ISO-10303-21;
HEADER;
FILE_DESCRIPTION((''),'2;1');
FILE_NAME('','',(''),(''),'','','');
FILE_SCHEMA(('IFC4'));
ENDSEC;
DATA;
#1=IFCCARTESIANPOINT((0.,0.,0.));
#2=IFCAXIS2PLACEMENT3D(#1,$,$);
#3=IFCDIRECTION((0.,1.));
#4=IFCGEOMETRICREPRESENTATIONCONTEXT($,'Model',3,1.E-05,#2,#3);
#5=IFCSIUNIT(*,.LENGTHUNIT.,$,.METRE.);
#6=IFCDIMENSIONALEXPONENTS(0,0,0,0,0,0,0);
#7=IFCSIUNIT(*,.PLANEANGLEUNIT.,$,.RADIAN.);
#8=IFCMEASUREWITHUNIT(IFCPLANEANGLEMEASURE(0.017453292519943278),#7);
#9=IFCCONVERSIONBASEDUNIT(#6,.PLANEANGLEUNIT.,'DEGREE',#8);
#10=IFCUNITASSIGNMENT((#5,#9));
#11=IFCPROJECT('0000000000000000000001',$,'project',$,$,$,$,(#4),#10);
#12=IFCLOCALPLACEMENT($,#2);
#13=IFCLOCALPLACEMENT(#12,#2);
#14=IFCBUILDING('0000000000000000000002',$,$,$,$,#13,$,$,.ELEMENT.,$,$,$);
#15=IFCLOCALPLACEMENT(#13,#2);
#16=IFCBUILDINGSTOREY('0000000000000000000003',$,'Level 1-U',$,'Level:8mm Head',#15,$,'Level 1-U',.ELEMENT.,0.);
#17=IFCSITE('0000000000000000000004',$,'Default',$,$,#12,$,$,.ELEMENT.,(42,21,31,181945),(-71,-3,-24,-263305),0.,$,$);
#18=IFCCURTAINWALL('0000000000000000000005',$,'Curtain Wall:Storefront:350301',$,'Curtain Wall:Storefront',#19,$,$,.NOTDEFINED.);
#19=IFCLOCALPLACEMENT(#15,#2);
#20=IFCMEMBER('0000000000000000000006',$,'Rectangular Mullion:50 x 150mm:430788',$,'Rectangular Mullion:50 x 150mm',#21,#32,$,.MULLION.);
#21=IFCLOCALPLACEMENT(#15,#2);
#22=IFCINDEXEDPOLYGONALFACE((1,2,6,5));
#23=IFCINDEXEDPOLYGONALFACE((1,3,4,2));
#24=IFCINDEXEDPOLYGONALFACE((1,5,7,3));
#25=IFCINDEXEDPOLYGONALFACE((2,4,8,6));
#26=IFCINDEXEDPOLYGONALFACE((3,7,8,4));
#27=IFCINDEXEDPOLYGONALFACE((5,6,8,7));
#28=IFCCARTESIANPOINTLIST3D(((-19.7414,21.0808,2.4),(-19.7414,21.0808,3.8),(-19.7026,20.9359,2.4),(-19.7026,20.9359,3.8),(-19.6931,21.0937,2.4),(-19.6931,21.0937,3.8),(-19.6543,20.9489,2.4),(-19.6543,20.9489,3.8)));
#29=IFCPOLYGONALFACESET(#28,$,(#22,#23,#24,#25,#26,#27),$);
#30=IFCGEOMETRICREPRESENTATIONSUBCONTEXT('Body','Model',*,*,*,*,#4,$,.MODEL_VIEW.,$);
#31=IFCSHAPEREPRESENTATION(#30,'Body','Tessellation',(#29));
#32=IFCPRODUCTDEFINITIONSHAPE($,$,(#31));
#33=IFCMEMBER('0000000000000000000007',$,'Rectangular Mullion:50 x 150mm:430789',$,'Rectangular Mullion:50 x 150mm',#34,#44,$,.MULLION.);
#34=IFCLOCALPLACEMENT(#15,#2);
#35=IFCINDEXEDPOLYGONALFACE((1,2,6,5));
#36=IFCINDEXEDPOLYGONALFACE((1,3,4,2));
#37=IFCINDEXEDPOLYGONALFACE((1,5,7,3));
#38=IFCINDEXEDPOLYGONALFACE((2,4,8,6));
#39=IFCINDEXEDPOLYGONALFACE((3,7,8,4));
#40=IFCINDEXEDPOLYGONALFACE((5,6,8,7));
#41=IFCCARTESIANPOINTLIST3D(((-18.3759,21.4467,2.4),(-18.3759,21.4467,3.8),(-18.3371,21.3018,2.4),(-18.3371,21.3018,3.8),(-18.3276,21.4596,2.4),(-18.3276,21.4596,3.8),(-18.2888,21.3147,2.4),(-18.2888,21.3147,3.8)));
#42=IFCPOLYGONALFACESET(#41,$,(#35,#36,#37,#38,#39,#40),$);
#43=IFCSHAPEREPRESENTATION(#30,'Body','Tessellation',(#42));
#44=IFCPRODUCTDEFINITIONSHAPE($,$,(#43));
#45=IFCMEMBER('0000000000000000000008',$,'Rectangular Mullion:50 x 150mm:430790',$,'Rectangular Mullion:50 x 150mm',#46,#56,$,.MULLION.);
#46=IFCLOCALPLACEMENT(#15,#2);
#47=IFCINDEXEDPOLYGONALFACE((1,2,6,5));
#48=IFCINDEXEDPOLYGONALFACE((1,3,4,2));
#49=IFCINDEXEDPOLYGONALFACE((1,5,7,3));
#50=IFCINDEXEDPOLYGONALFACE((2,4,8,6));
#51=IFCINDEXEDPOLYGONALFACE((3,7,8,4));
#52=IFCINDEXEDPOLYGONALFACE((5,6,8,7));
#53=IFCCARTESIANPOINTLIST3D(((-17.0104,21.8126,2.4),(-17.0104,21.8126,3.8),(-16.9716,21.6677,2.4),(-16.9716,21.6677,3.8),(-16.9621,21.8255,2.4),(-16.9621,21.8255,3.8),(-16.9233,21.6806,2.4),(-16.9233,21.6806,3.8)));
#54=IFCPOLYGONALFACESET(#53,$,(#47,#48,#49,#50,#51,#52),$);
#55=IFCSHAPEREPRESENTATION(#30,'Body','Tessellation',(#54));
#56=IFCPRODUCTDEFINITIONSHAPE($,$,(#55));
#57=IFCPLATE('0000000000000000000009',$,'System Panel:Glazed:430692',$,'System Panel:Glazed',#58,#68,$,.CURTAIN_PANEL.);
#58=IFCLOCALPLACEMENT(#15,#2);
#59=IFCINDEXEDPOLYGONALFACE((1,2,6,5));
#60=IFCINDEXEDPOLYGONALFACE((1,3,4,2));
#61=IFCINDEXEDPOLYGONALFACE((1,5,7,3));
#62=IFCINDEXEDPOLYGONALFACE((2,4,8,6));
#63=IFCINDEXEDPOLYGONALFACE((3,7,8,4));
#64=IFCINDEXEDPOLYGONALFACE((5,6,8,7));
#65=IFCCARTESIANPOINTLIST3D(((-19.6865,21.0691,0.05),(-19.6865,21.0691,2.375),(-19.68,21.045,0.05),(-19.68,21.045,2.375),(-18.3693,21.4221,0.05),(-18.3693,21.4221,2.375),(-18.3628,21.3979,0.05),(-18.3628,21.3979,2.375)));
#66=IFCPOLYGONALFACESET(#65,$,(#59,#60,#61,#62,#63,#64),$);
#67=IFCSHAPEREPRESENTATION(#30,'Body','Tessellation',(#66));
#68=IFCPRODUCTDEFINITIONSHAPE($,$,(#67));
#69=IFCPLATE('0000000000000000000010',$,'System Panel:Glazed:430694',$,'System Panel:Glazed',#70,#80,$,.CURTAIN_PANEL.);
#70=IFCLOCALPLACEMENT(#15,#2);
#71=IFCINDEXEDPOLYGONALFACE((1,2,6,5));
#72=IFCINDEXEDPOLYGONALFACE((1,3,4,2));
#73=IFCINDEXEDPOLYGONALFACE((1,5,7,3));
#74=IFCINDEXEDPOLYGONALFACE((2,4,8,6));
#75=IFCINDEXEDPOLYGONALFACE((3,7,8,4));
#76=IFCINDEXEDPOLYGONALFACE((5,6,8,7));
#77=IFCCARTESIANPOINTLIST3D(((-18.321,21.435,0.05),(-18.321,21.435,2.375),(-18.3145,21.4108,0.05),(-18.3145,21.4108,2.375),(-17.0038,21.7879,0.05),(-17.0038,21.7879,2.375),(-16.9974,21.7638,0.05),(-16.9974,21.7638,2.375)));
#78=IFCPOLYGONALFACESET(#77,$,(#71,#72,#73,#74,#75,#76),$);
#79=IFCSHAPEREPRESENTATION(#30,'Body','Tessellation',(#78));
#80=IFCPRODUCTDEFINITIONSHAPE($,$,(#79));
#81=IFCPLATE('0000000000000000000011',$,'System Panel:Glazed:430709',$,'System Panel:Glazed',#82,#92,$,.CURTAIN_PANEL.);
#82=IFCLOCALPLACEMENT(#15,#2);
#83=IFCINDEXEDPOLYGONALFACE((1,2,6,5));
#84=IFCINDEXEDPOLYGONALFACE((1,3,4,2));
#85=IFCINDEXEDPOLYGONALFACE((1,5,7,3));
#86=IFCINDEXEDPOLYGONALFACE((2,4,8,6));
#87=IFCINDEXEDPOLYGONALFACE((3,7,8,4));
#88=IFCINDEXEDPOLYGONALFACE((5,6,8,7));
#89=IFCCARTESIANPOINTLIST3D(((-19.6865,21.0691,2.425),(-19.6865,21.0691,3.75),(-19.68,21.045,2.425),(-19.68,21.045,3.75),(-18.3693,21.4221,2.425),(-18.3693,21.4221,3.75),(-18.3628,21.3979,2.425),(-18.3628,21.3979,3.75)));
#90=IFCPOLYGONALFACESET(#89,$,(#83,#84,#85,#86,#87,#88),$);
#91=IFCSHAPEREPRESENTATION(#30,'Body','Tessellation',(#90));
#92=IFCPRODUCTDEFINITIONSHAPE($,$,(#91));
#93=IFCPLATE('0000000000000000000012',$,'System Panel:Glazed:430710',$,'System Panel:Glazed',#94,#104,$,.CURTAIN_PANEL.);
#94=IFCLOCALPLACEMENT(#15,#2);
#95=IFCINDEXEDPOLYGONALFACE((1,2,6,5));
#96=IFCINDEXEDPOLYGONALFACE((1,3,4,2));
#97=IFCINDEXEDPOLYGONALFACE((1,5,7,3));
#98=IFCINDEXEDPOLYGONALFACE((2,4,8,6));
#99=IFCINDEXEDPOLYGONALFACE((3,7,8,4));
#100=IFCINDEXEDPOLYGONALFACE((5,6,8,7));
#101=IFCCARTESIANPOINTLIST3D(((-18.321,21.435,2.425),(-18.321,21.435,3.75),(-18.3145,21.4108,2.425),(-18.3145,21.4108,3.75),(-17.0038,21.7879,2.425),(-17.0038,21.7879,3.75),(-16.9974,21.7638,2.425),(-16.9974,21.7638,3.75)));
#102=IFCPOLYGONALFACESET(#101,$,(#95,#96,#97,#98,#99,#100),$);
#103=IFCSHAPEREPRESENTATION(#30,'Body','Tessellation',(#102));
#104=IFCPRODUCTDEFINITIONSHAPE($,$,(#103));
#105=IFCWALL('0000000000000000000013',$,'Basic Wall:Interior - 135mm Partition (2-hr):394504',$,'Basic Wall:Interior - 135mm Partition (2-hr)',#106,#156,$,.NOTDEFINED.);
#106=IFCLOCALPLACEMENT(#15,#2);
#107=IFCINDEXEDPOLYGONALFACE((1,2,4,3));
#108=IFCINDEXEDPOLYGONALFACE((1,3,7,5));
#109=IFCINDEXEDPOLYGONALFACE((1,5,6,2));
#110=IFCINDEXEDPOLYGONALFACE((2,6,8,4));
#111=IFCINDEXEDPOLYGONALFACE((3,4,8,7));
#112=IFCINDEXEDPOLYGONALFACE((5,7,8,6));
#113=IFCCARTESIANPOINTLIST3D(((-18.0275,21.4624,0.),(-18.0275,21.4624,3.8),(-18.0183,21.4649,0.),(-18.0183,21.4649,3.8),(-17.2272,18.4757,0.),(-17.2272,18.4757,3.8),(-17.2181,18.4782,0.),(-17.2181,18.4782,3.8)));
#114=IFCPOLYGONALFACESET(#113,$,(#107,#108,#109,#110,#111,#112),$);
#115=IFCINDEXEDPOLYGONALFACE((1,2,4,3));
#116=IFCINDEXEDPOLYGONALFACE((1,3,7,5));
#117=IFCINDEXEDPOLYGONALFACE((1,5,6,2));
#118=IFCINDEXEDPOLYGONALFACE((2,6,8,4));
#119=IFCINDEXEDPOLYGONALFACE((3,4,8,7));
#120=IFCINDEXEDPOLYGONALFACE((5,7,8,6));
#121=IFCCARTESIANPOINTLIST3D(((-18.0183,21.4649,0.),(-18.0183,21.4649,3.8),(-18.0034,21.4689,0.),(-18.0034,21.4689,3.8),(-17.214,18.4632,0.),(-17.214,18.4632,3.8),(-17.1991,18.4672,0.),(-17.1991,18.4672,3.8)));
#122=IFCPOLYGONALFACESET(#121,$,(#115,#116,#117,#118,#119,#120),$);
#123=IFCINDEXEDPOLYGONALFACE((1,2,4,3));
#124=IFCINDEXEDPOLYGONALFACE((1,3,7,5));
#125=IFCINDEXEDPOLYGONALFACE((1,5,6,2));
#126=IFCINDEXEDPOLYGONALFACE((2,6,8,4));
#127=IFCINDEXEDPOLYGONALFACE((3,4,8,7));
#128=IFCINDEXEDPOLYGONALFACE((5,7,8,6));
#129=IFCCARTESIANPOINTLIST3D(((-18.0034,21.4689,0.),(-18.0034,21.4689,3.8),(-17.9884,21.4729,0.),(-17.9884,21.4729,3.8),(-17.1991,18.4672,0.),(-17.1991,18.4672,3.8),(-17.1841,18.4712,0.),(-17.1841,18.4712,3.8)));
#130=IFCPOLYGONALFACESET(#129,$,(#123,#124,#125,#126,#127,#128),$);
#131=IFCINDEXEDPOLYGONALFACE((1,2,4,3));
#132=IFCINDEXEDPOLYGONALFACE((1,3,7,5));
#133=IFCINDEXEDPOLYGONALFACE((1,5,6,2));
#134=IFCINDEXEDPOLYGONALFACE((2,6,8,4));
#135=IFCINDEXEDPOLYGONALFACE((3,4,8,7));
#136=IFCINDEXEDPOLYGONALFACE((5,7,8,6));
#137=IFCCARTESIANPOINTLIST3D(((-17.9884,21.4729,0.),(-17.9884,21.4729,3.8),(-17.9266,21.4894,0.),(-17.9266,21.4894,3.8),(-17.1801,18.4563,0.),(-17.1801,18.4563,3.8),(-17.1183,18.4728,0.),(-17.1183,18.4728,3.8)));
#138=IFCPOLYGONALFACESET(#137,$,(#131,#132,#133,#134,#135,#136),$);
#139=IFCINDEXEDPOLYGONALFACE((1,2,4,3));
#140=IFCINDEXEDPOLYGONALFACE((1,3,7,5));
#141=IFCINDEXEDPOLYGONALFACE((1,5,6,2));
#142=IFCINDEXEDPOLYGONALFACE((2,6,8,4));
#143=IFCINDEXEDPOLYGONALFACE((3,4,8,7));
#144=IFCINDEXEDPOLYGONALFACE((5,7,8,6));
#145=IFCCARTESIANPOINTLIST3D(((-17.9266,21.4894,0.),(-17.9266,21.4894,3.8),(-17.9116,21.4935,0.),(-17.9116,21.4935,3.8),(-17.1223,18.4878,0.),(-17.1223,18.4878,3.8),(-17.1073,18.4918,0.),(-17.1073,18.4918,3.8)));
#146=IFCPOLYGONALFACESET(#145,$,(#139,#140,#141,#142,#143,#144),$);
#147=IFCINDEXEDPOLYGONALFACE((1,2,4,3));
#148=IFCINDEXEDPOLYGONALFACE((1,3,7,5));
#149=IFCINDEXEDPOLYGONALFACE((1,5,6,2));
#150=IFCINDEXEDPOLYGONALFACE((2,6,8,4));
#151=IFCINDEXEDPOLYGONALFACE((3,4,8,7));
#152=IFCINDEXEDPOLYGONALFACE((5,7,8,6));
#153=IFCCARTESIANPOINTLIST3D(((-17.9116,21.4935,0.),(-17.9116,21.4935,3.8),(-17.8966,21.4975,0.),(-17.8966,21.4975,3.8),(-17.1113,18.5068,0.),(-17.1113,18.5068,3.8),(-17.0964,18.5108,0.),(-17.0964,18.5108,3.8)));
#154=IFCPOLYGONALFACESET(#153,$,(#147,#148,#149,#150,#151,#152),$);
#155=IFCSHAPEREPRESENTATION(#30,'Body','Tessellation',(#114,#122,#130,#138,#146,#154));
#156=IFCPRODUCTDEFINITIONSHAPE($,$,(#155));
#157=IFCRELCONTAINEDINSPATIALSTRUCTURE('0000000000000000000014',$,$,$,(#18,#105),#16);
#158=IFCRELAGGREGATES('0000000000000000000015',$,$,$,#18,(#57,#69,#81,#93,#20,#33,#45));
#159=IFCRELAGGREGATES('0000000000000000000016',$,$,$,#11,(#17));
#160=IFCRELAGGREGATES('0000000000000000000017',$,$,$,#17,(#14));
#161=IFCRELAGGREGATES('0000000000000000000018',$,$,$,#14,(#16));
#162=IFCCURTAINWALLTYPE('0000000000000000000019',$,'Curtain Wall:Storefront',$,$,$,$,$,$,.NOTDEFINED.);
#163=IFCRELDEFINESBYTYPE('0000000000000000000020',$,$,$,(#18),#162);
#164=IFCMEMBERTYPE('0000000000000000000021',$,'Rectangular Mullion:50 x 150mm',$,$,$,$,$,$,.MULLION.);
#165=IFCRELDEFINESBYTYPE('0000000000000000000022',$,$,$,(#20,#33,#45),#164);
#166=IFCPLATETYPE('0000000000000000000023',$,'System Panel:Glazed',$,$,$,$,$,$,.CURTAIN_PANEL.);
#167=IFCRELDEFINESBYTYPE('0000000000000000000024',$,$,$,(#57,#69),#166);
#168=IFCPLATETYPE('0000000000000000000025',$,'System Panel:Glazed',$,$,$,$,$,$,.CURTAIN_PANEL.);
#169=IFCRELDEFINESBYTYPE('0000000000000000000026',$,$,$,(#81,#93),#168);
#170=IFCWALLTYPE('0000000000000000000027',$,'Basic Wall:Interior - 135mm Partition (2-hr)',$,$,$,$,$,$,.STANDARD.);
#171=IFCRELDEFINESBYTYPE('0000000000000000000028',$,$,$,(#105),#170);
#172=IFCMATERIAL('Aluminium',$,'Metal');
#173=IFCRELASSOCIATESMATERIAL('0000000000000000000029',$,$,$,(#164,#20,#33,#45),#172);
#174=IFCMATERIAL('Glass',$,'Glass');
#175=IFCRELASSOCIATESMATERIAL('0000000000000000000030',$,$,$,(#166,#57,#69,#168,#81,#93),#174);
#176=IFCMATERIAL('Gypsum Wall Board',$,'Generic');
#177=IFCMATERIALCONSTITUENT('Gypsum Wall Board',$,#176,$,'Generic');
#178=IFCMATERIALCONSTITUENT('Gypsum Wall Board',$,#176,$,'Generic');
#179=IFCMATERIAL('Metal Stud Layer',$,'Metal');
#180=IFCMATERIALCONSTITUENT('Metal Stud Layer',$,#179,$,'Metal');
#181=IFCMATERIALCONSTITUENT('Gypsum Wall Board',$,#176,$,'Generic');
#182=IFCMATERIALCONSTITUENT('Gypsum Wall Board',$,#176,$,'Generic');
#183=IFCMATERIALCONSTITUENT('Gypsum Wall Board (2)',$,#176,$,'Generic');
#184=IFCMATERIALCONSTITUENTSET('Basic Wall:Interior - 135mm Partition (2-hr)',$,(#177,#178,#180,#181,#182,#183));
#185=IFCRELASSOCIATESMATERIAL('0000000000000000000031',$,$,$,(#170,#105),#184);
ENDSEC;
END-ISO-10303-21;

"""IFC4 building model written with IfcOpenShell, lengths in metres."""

from ifc_helpers import new_model, entity, si_unit, converted_unit, direction, frame, origin, place, context, subcontext, project, spatial, indexed_curve, outline, extrude, source, transform, mapped, material, constituent, constituent_set, type_object, type_shapes, element, aggregate, save


model = new_model("IFC4")

# Units and contexts
model_context = context("Model", 3, precision=1e-05, world=origin(), true_north=direction((0.0, 1.0)))
body_context = subcontext(model_context, "Body", "Model", "MODEL_VIEW")
ifc_project = project(units=[si_unit("LENGTHUNIT", "METRE"), converted_unit("PLANEANGLEUNIT", "DEGREE", entity("IfcPlaneAngleMeasure", 0.017453292519943278), si_unit("PLANEANGLEUNIT", "RADIAN"), dimensions=[0, 0, 0, 0, 0, 0, 0])], contexts=[model_context])

# Site, building, storey
site_placement = place(None, origin())
site = spatial("IfcSite", under=ifc_project, at=site_placement, Name="Default", CompositionType="ELEMENT", RefLatitude=(42, 21, 31, 181945), RefLongitude=(-71, -3, -24, -263305), RefElevation=0.0)
building_placement = place(site_placement, origin())
building = spatial("IfcBuilding", under=site, at=building_placement, CompositionType="ELEMENT")
storey_placement = place(building_placement, origin())
storey = spatial("IfcBuildingStorey", under=building, at=storey_placement, Name="Level 1-U", ObjectType="Level:8mm Head", LongName="Level 1-U", CompositionType="ELEMENT", Elevation=0.0)

# Curtain wall, members, plates
curtain_wall_type = type_object("IfcCurtainWallType", Name="Curtain Wall:Storefront", PredefinedType="NOTDEFINED")
curtain_wall_placement = place(storey_placement, origin())
curtain_wall = element("IfcCurtainWall", 1, at=curtain_wall_placement, inside=storey, type_object=curtain_wall_type, Name="Curtain Wall:Storefront:350301", ObjectType="Curtain Wall:Storefront", PredefinedType="NOTDEFINED")
ifc_material_1 = material(Name="Aluminium", Category="Metal")
member_type_1 = type_object("IfcMemberType", Name="Rectangular Mullion:50 x 150mm", PredefinedType="MULLION", material=ifc_material_1)
shared_shape_1 = source(origin(), body_context, "Body", "SweptSolid", [
    extrude(outline(indexed_curve([(-0.025, -0.075), (0.025, -0.075), (0.025, 0.075), (-0.025, 0.075), (-0.025, -0.075)], self_intersect=False)), frame((0.0, 0.0, -1.4), z_axis=(0.0, 0.0, 1.0), x_axis=(-1.0, 0.0, 0.0)), (0.0, 0.0, 1.0), 1.4),
])
type_shapes(member_type_1, [shared_shape_1])
member_1_placement = place(curtain_wall_placement, frame((-19.6978, 21.0148, 2.4), z_axis=(0.0, 0.0, -1.0), x_axis=(0.965926, 0.258819, 0.0)))
member_1 = element("IfcMember", 2, at=member_1_placement, type_object=member_type_1, material=ifc_material_1, Name="Rectangular Mullion:50 x 150mm:430788", ObjectType="Rectangular Mullion:50 x 150mm", PredefinedType="MULLION", context=body_context, shape_type="MappedRepresentation", body=[
    mapped(shared_shape_1, transform((0.0, 0.0, 0.0), scale=1.0)),
])
member_2_placement = place(curtain_wall_placement, frame((-18.3324, 21.3807, 2.4), z_axis=(0.0, 0.0, -1.0), x_axis=(0.965926, 0.258819, 0.0)))
member_2 = element("IfcMember", 3, at=member_2_placement, type_object=member_type_1, material=ifc_material_1, Name="Rectangular Mullion:50 x 150mm:430789", ObjectType="Rectangular Mullion:50 x 150mm", PredefinedType="MULLION", context=body_context, shape_type="MappedRepresentation", body=[
    mapped(shared_shape_1, transform((0.0, 0.0, 0.0), scale=1.0)),
])
member_3_placement = place(curtain_wall_placement, frame((-16.9669, 21.7466, 2.4), z_axis=(0.0, 0.0, -1.0), x_axis=(0.965926, 0.258819, 0.0)))
member_3 = element("IfcMember", 4, at=member_3_placement, type_object=member_type_1, material=ifc_material_1, Name="Rectangular Mullion:50 x 150mm:430790", ObjectType="Rectangular Mullion:50 x 150mm", PredefinedType="MULLION", context=body_context, shape_type="MappedRepresentation", body=[
    mapped(shared_shape_1, transform((0.0, 0.0, 0.0), scale=1.0)),
])
ifc_material_2 = material(Name="Glass", Category="Glass")
plate_type_1 = type_object("IfcPlateType", Name="System Panel:Glazed", PredefinedType="CURTAIN_PANEL", material=ifc_material_2)
shared_shape_2 = source(origin(), body_context, "Body", "SweptSolid", [
    extrude(outline(indexed_curve([(-0.0125, -0.6818), (0.0125, -0.6818), (0.0125, 0.6818), (-0.0125, 0.6818), (-0.0125, -0.6818)], self_intersect=False)), frame((0.0, 0.037, 0.0), z_axis=(0.0, 0.0, 1.0), x_axis=(0.0, 1.0, 0.0)), (0.0, 0.0, 1.0), 2.325),
])
type_shapes(plate_type_1, [shared_shape_2])
plate_1_placement = place(curtain_wall_placement, frame((-19.0151, 21.1978, 0.05), z_axis=(0.0, 0.0, 1.0), x_axis=(0.965926, 0.258819, 0.0)))
plate_1 = element("IfcPlate", 5, at=plate_1_placement, type_object=plate_type_1, material=ifc_material_2, Name="System Panel:Glazed:430692", ObjectType="System Panel:Glazed", PredefinedType="CURTAIN_PANEL", context=body_context, shape_type="MappedRepresentation", body=[
    mapped(shared_shape_2, transform((0.0, 0.0, 0.0), scale=1.0)),
])
plate_2_placement = place(curtain_wall_placement, frame((-17.6496, 21.5636, 0.05), z_axis=(0.0, 0.0, 1.0), x_axis=(0.965926, 0.258819, 0.0)))
plate_2 = element("IfcPlate", 6, at=plate_2_placement, type_object=plate_type_1, material=ifc_material_2, Name="System Panel:Glazed:430694", ObjectType="System Panel:Glazed", PredefinedType="CURTAIN_PANEL", context=body_context, shape_type="MappedRepresentation", body=[
    mapped(shared_shape_2, transform((0.0, 0.0, 0.0), scale=1.0)),
])
plate_type_2 = type_object("IfcPlateType", Name="System Panel:Glazed", PredefinedType="CURTAIN_PANEL", material=ifc_material_2)
shared_shape_3 = source(origin(), body_context, "Body", "SweptSolid", [
    extrude(outline(indexed_curve([(-0.0125, -0.6818), (0.0125, -0.6818), (0.0125, 0.6818), (-0.0125, 0.6818), (-0.0125, -0.6818)], self_intersect=False)), frame((0.0, 0.037, 0.0), z_axis=(0.0, 0.0, 1.0), x_axis=(0.0, 1.0, 0.0)), (0.0, 0.0, 1.0), 1.325),
])
type_shapes(plate_type_2, [shared_shape_3])
plate_3_placement = place(curtain_wall_placement, frame((-19.0151, 21.1978, 2.425), z_axis=(0.0, 0.0, 1.0), x_axis=(0.965926, 0.258819, 0.0)))
plate_3 = element("IfcPlate", 7, at=plate_3_placement, type_object=plate_type_2, material=ifc_material_2, Name="System Panel:Glazed:430709", ObjectType="System Panel:Glazed", PredefinedType="CURTAIN_PANEL", context=body_context, shape_type="MappedRepresentation", body=[
    mapped(shared_shape_3, transform((0.0, 0.0, 0.0), scale=1.0)),
])
plate_4_placement = place(curtain_wall_placement, frame((-17.6496, 21.5636, 2.425), z_axis=(0.0, 0.0, 1.0), x_axis=(0.965926, 0.258819, 0.0)))
plate_4 = element("IfcPlate", 8, at=plate_4_placement, type_object=plate_type_2, material=ifc_material_2, Name="System Panel:Glazed:430710", ObjectType="System Panel:Glazed", PredefinedType="CURTAIN_PANEL", context=body_context, shape_type="MappedRepresentation", body=[
    mapped(shared_shape_3, transform((0.0, 0.0, 0.0), scale=1.0)),
])
aggregate(curtain_wall, [plate_1, plate_2, plate_3, plate_4, member_1, member_2, member_3])

# Wall
ifc_material_3 = material(Name="Gypsum Wall Board", Category="Generic")
ifc_constituent_1 = constituent(ifc_material_3, Name="Gypsum Wall Board", Category="Generic")
ifc_constituent_2 = constituent(ifc_material_3, Name="Gypsum Wall Board", Category="Generic")
ifc_material_4 = material(Name="Metal Stud Layer", Category="Metal")
ifc_constituent_3 = constituent(ifc_material_4, Name="Metal Stud Layer", Category="Metal")
ifc_constituent_4 = constituent(ifc_material_3, Name="Gypsum Wall Board", Category="Generic")
ifc_constituent_5 = constituent(ifc_material_3, Name="Gypsum Wall Board", Category="Generic")
ifc_constituent_6 = constituent(ifc_material_3, Name="Gypsum Wall Board (2)", Category="Generic")
ifc_constituent_set = constituent_set(constituents=[ifc_constituent_1, ifc_constituent_2, ifc_constituent_3, ifc_constituent_4, ifc_constituent_5, ifc_constituent_6], Name="Basic Wall:Interior - 135mm Partition (2-hr)")
wall_type = type_object("IfcWallType", Name="Basic Wall:Interior - 135mm Partition (2-hr)", PredefinedType="STANDARD", material=ifc_constituent_set)
wall_placement = place(storey_placement, frame((-17.9621, 21.4799, 0.0), z_axis=(0.0, 0.0, 1.0), x_axis=(0.258819, -0.965926, 0.0)))
element("IfcWall", 9, at=wall_placement, inside=storey, type_object=wall_type, material=ifc_constituent_set, Name="Basic Wall:Interior - 135mm Partition (2-hr):394504", ObjectType="Basic Wall:Interior - 135mm Partition (2-hr)", PredefinedType="NOTDEFINED", context=body_context, shape_type="SweptSolid", body=[
    extrude(outline(indexed_curve([(-0.0048, -1.546), (0.0047, -1.546), (0.0048, 1.546), (-0.0047, 1.546), (-0.0048, -1.546)], self_intersect=False)), frame((1.546, -0.063, 0.0), z_axis=(0.0, 0.0, 1.0), x_axis=(0.0, 1.0, 0.0)), (0.0, 0.0, 1.0), 3.8),
    extrude(outline(indexed_curve([(-1.5538, -0.0078), (1.5538, -0.0077), (1.5538, 0.0078), (-1.5538, 0.0077), (-1.5538, -0.0078)], self_intersect=False)), frame((1.5538, -0.0505, 0.0)), (0.0, 0.0, 1.0), 3.8),
    extrude(outline(indexed_curve([(-1.5538, -0.0078), (1.5538, -0.0077), (1.5538, 0.0078), (-1.5538, 0.0077), (-1.5538, -0.0078)], self_intersect=False)), frame((1.5538, -0.035, 0.0)), (0.0, 0.0, 1.0), 3.8),
    extrude(outline(indexed_curve([(-1.5615, -0.032), (1.5615, -0.032), (1.5615, 0.032), (-1.5615, 0.032), (-1.5615, -0.032)], self_intersect=False)), frame((1.5615, 0.0048, 0.0)), (0.0, 0.0, 1.0), 3.8),
    extrude(outline(indexed_curve([(-1.5538, -0.0077), (1.5538, -0.0078), (1.5538, 0.0077), (-1.5538, 0.0078), (-1.5538, -0.0077)], self_intersect=False)), frame((1.5538, 0.0445, 0.0)), (0.0, 0.0, 1.0), 3.8),
    extrude(outline(indexed_curve([(-0.0078, -1.546), (0.0077, -1.546), (0.0078, 1.546), (-0.0077, 1.546), (-0.0078, -1.546)], self_intersect=False)), frame((1.546, 0.06, 0.0), z_axis=(0.0, 0.0, 1.0), x_axis=(0.0, -1.0, 0.0)), (0.0, 0.0, 1.0), 3.8),
])

save(model, "model.ifc")
